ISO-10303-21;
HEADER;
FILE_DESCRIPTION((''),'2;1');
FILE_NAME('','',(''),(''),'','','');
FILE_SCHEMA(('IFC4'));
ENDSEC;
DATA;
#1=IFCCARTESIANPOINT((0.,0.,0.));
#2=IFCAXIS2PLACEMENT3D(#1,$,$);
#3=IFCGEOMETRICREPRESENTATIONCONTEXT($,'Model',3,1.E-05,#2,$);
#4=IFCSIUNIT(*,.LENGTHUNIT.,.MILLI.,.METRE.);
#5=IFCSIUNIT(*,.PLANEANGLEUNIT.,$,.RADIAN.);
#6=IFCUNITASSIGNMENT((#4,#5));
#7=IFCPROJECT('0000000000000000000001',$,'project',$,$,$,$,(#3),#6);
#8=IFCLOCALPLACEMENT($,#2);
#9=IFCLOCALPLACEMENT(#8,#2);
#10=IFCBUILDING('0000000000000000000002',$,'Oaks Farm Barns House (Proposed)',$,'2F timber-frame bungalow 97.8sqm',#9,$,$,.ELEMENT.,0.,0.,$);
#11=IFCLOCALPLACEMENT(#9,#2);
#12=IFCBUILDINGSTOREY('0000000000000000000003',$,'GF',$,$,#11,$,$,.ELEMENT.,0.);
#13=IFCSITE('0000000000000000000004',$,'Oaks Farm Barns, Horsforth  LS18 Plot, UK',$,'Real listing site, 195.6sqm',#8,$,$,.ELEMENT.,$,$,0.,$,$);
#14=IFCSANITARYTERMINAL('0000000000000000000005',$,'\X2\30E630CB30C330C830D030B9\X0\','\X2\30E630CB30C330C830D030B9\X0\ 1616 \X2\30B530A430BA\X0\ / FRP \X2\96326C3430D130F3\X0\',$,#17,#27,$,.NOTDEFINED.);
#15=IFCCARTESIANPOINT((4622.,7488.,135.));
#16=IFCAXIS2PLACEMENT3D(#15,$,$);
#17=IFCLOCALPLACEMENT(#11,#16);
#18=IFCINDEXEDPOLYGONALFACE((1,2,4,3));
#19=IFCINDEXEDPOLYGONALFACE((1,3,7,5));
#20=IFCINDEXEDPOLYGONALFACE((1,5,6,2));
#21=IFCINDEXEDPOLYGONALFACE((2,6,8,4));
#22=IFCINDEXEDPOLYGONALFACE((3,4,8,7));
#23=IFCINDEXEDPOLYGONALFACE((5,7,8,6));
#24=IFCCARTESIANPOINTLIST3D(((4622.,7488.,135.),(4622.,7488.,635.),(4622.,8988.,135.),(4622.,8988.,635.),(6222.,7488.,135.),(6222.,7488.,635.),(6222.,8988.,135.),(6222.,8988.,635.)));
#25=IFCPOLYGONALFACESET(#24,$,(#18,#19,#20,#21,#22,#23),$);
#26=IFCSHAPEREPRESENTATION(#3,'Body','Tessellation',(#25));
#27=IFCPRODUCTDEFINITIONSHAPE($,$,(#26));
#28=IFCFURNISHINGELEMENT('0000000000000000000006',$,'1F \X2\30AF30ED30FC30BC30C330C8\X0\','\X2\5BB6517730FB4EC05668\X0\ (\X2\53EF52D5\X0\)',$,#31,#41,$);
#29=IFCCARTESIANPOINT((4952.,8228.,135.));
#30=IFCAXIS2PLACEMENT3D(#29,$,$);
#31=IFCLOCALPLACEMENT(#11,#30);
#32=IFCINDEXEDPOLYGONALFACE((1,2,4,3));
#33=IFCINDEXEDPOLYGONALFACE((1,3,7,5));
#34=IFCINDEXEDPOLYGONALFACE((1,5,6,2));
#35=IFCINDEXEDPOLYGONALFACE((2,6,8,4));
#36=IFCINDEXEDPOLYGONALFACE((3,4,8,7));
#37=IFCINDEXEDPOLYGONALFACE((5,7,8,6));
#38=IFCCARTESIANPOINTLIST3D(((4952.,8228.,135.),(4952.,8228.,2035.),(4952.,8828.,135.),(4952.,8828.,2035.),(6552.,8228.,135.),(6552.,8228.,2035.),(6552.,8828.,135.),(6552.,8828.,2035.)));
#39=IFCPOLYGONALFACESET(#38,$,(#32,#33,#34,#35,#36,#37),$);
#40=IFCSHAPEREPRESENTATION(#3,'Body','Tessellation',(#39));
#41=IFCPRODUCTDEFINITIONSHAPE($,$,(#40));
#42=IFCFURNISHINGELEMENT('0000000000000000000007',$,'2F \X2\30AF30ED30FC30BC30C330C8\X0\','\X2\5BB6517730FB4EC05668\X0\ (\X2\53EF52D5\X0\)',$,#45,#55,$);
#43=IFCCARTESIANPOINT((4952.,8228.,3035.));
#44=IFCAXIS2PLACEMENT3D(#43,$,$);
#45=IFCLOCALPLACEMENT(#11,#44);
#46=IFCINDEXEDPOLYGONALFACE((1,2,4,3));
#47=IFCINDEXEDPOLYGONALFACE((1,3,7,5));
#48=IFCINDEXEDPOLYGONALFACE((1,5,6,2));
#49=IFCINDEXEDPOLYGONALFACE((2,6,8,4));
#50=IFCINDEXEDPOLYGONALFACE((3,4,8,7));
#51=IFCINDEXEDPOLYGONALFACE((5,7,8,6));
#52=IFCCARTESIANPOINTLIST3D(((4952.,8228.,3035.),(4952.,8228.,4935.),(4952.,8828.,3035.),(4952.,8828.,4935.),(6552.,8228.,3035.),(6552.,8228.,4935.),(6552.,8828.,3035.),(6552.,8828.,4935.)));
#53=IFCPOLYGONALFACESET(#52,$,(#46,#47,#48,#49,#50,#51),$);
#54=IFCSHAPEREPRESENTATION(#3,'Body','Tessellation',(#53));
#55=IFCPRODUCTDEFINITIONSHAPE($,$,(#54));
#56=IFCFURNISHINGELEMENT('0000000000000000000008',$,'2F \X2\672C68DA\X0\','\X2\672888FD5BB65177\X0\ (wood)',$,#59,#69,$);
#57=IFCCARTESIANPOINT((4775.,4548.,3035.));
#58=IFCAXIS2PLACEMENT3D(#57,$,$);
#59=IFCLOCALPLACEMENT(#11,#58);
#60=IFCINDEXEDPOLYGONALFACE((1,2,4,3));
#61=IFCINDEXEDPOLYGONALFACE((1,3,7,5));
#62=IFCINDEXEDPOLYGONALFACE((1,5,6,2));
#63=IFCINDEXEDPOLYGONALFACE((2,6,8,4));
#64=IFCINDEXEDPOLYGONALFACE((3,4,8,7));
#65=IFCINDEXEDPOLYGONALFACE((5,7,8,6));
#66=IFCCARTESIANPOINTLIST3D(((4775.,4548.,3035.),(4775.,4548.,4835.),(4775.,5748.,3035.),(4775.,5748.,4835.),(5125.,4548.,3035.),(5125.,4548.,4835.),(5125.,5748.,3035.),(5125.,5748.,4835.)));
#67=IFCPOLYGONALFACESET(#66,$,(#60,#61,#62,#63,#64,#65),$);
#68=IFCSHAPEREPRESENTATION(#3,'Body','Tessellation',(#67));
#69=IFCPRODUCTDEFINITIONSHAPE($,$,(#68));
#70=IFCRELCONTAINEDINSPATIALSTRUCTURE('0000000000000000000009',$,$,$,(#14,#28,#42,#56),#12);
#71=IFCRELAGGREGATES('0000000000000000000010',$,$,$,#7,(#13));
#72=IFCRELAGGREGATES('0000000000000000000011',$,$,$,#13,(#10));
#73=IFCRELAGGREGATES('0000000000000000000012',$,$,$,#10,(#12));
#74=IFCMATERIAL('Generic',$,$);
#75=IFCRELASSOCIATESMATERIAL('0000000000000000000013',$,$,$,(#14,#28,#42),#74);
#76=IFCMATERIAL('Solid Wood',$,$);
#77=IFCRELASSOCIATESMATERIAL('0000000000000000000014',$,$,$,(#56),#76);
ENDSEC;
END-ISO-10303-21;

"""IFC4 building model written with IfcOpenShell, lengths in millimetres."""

from ifc_helpers import new_model, si_unit, frame, frame_2d, origin, place, context, project, spatial, rectangle, extrude, material, element, save


model = new_model("IFC4")

# Units and contexts
model_context = context("Model", 3, precision=1e-05, world=origin())
ifc_project = project(units=[si_unit("LENGTHUNIT", "METRE", prefix="MILLI"), si_unit("PLANEANGLEUNIT", "RADIAN")], contexts=[model_context])

# Site, building, storey
site_placement = place(None, origin())
site = spatial("IfcSite", under=ifc_project, at=site_placement, Name="Oaks Farm Barns, Horsforth  LS18 Plot, UK", ObjectType="Real listing site, 195.6sqm", CompositionType="ELEMENT", RefElevation=0.0)
building_placement = place(site_placement, origin())
building = spatial("IfcBuilding", under=site, at=building_placement, Name="Oaks Farm Barns House (Proposed)", ObjectType="2F timber-frame bungalow 97.8sqm", CompositionType="ELEMENT", ElevationOfRefHeight=0.0, ElevationOfTerrain=0.0)
storey_placement = place(building_placement, origin())
storey = spatial("IfcBuildingStorey", under=building, at=storey_placement, Name="GF", CompositionType="ELEMENT", Elevation=0.0)

# Shared definitions
ifc_material_1 = material(Name="Solid Wood")

# Shared definitions
ifc_material_2 = material(Name="Generic")

# Sanitary terminal
sanitary_terminal_placement = place(storey_placement, frame((4622.0, 7488.0, 135.0)))
element("IfcSanitaryTerminal", 1, at=sanitary_terminal_placement, inside=storey, material=ifc_material_2, Name="ユニットバス", Description="ユニットバス 1616 サイズ / FRP 防水パン", PredefinedType="NOTDEFINED", context=model_context, shape_type="SweptSolid", body=[
    extrude(rectangle(XDim=1600.0, YDim=1500.0, at=frame_2d((800.0, 750.0))), frame((4622.0, 7488.0, 135.0)), (0.0, 0.0, 1.0), 500.0),
])

# Furnishing elements
furnishing_1_placement = place(storey_placement, frame((4952.0, 8228.0, 135.0)))
element("IfcFurnishingElement", 2, at=furnishing_1_placement, inside=storey, material=ifc_material_2, Name="1F クローゼット", Description="家具・什器 (可動)", context=model_context, shape_type="SweptSolid", body=[
    extrude(rectangle(XDim=1600.0, YDim=600.0, at=frame_2d((800.0, 300.0))), frame((4952.0, 8228.0, 135.0)), (0.0, 0.0, 1.0), 1900.0),
])
furnishing_2_placement = place(storey_placement, frame((4952.0, 8228.0, 3035.0)))
element("IfcFurnishingElement", 3, at=furnishing_2_placement, inside=storey, material=ifc_material_2, Name="2F クローゼット", Description="家具・什器 (可動)", context=model_context, shape_type="SweptSolid", body=[
    extrude(rectangle(XDim=1600.0, YDim=600.0, at=frame_2d((800.0, 300.0))), frame((4952.0, 8228.0, 3035.0)), (0.0, 0.0, 1.0), 1900.0),
])
furnishing_3_placement = place(storey_placement, frame((4775.0, 4548.0, 3035.0)))
element("IfcFurnishingElement", 4, at=furnishing_3_placement, inside=storey, material=ifc_material_1, Name="2F 本棚", Description="木製家具 (wood)", context=model_context, shape_type="SweptSolid", body=[
    extrude(rectangle(XDim=350.0, YDim=1200.0, at=frame_2d((175.0, 600.0))), frame((4775.0, 4548.0, 3035.0)), (0.0, 0.0, 1.0), 1800.0),
])

save(model, "model.ifc")
